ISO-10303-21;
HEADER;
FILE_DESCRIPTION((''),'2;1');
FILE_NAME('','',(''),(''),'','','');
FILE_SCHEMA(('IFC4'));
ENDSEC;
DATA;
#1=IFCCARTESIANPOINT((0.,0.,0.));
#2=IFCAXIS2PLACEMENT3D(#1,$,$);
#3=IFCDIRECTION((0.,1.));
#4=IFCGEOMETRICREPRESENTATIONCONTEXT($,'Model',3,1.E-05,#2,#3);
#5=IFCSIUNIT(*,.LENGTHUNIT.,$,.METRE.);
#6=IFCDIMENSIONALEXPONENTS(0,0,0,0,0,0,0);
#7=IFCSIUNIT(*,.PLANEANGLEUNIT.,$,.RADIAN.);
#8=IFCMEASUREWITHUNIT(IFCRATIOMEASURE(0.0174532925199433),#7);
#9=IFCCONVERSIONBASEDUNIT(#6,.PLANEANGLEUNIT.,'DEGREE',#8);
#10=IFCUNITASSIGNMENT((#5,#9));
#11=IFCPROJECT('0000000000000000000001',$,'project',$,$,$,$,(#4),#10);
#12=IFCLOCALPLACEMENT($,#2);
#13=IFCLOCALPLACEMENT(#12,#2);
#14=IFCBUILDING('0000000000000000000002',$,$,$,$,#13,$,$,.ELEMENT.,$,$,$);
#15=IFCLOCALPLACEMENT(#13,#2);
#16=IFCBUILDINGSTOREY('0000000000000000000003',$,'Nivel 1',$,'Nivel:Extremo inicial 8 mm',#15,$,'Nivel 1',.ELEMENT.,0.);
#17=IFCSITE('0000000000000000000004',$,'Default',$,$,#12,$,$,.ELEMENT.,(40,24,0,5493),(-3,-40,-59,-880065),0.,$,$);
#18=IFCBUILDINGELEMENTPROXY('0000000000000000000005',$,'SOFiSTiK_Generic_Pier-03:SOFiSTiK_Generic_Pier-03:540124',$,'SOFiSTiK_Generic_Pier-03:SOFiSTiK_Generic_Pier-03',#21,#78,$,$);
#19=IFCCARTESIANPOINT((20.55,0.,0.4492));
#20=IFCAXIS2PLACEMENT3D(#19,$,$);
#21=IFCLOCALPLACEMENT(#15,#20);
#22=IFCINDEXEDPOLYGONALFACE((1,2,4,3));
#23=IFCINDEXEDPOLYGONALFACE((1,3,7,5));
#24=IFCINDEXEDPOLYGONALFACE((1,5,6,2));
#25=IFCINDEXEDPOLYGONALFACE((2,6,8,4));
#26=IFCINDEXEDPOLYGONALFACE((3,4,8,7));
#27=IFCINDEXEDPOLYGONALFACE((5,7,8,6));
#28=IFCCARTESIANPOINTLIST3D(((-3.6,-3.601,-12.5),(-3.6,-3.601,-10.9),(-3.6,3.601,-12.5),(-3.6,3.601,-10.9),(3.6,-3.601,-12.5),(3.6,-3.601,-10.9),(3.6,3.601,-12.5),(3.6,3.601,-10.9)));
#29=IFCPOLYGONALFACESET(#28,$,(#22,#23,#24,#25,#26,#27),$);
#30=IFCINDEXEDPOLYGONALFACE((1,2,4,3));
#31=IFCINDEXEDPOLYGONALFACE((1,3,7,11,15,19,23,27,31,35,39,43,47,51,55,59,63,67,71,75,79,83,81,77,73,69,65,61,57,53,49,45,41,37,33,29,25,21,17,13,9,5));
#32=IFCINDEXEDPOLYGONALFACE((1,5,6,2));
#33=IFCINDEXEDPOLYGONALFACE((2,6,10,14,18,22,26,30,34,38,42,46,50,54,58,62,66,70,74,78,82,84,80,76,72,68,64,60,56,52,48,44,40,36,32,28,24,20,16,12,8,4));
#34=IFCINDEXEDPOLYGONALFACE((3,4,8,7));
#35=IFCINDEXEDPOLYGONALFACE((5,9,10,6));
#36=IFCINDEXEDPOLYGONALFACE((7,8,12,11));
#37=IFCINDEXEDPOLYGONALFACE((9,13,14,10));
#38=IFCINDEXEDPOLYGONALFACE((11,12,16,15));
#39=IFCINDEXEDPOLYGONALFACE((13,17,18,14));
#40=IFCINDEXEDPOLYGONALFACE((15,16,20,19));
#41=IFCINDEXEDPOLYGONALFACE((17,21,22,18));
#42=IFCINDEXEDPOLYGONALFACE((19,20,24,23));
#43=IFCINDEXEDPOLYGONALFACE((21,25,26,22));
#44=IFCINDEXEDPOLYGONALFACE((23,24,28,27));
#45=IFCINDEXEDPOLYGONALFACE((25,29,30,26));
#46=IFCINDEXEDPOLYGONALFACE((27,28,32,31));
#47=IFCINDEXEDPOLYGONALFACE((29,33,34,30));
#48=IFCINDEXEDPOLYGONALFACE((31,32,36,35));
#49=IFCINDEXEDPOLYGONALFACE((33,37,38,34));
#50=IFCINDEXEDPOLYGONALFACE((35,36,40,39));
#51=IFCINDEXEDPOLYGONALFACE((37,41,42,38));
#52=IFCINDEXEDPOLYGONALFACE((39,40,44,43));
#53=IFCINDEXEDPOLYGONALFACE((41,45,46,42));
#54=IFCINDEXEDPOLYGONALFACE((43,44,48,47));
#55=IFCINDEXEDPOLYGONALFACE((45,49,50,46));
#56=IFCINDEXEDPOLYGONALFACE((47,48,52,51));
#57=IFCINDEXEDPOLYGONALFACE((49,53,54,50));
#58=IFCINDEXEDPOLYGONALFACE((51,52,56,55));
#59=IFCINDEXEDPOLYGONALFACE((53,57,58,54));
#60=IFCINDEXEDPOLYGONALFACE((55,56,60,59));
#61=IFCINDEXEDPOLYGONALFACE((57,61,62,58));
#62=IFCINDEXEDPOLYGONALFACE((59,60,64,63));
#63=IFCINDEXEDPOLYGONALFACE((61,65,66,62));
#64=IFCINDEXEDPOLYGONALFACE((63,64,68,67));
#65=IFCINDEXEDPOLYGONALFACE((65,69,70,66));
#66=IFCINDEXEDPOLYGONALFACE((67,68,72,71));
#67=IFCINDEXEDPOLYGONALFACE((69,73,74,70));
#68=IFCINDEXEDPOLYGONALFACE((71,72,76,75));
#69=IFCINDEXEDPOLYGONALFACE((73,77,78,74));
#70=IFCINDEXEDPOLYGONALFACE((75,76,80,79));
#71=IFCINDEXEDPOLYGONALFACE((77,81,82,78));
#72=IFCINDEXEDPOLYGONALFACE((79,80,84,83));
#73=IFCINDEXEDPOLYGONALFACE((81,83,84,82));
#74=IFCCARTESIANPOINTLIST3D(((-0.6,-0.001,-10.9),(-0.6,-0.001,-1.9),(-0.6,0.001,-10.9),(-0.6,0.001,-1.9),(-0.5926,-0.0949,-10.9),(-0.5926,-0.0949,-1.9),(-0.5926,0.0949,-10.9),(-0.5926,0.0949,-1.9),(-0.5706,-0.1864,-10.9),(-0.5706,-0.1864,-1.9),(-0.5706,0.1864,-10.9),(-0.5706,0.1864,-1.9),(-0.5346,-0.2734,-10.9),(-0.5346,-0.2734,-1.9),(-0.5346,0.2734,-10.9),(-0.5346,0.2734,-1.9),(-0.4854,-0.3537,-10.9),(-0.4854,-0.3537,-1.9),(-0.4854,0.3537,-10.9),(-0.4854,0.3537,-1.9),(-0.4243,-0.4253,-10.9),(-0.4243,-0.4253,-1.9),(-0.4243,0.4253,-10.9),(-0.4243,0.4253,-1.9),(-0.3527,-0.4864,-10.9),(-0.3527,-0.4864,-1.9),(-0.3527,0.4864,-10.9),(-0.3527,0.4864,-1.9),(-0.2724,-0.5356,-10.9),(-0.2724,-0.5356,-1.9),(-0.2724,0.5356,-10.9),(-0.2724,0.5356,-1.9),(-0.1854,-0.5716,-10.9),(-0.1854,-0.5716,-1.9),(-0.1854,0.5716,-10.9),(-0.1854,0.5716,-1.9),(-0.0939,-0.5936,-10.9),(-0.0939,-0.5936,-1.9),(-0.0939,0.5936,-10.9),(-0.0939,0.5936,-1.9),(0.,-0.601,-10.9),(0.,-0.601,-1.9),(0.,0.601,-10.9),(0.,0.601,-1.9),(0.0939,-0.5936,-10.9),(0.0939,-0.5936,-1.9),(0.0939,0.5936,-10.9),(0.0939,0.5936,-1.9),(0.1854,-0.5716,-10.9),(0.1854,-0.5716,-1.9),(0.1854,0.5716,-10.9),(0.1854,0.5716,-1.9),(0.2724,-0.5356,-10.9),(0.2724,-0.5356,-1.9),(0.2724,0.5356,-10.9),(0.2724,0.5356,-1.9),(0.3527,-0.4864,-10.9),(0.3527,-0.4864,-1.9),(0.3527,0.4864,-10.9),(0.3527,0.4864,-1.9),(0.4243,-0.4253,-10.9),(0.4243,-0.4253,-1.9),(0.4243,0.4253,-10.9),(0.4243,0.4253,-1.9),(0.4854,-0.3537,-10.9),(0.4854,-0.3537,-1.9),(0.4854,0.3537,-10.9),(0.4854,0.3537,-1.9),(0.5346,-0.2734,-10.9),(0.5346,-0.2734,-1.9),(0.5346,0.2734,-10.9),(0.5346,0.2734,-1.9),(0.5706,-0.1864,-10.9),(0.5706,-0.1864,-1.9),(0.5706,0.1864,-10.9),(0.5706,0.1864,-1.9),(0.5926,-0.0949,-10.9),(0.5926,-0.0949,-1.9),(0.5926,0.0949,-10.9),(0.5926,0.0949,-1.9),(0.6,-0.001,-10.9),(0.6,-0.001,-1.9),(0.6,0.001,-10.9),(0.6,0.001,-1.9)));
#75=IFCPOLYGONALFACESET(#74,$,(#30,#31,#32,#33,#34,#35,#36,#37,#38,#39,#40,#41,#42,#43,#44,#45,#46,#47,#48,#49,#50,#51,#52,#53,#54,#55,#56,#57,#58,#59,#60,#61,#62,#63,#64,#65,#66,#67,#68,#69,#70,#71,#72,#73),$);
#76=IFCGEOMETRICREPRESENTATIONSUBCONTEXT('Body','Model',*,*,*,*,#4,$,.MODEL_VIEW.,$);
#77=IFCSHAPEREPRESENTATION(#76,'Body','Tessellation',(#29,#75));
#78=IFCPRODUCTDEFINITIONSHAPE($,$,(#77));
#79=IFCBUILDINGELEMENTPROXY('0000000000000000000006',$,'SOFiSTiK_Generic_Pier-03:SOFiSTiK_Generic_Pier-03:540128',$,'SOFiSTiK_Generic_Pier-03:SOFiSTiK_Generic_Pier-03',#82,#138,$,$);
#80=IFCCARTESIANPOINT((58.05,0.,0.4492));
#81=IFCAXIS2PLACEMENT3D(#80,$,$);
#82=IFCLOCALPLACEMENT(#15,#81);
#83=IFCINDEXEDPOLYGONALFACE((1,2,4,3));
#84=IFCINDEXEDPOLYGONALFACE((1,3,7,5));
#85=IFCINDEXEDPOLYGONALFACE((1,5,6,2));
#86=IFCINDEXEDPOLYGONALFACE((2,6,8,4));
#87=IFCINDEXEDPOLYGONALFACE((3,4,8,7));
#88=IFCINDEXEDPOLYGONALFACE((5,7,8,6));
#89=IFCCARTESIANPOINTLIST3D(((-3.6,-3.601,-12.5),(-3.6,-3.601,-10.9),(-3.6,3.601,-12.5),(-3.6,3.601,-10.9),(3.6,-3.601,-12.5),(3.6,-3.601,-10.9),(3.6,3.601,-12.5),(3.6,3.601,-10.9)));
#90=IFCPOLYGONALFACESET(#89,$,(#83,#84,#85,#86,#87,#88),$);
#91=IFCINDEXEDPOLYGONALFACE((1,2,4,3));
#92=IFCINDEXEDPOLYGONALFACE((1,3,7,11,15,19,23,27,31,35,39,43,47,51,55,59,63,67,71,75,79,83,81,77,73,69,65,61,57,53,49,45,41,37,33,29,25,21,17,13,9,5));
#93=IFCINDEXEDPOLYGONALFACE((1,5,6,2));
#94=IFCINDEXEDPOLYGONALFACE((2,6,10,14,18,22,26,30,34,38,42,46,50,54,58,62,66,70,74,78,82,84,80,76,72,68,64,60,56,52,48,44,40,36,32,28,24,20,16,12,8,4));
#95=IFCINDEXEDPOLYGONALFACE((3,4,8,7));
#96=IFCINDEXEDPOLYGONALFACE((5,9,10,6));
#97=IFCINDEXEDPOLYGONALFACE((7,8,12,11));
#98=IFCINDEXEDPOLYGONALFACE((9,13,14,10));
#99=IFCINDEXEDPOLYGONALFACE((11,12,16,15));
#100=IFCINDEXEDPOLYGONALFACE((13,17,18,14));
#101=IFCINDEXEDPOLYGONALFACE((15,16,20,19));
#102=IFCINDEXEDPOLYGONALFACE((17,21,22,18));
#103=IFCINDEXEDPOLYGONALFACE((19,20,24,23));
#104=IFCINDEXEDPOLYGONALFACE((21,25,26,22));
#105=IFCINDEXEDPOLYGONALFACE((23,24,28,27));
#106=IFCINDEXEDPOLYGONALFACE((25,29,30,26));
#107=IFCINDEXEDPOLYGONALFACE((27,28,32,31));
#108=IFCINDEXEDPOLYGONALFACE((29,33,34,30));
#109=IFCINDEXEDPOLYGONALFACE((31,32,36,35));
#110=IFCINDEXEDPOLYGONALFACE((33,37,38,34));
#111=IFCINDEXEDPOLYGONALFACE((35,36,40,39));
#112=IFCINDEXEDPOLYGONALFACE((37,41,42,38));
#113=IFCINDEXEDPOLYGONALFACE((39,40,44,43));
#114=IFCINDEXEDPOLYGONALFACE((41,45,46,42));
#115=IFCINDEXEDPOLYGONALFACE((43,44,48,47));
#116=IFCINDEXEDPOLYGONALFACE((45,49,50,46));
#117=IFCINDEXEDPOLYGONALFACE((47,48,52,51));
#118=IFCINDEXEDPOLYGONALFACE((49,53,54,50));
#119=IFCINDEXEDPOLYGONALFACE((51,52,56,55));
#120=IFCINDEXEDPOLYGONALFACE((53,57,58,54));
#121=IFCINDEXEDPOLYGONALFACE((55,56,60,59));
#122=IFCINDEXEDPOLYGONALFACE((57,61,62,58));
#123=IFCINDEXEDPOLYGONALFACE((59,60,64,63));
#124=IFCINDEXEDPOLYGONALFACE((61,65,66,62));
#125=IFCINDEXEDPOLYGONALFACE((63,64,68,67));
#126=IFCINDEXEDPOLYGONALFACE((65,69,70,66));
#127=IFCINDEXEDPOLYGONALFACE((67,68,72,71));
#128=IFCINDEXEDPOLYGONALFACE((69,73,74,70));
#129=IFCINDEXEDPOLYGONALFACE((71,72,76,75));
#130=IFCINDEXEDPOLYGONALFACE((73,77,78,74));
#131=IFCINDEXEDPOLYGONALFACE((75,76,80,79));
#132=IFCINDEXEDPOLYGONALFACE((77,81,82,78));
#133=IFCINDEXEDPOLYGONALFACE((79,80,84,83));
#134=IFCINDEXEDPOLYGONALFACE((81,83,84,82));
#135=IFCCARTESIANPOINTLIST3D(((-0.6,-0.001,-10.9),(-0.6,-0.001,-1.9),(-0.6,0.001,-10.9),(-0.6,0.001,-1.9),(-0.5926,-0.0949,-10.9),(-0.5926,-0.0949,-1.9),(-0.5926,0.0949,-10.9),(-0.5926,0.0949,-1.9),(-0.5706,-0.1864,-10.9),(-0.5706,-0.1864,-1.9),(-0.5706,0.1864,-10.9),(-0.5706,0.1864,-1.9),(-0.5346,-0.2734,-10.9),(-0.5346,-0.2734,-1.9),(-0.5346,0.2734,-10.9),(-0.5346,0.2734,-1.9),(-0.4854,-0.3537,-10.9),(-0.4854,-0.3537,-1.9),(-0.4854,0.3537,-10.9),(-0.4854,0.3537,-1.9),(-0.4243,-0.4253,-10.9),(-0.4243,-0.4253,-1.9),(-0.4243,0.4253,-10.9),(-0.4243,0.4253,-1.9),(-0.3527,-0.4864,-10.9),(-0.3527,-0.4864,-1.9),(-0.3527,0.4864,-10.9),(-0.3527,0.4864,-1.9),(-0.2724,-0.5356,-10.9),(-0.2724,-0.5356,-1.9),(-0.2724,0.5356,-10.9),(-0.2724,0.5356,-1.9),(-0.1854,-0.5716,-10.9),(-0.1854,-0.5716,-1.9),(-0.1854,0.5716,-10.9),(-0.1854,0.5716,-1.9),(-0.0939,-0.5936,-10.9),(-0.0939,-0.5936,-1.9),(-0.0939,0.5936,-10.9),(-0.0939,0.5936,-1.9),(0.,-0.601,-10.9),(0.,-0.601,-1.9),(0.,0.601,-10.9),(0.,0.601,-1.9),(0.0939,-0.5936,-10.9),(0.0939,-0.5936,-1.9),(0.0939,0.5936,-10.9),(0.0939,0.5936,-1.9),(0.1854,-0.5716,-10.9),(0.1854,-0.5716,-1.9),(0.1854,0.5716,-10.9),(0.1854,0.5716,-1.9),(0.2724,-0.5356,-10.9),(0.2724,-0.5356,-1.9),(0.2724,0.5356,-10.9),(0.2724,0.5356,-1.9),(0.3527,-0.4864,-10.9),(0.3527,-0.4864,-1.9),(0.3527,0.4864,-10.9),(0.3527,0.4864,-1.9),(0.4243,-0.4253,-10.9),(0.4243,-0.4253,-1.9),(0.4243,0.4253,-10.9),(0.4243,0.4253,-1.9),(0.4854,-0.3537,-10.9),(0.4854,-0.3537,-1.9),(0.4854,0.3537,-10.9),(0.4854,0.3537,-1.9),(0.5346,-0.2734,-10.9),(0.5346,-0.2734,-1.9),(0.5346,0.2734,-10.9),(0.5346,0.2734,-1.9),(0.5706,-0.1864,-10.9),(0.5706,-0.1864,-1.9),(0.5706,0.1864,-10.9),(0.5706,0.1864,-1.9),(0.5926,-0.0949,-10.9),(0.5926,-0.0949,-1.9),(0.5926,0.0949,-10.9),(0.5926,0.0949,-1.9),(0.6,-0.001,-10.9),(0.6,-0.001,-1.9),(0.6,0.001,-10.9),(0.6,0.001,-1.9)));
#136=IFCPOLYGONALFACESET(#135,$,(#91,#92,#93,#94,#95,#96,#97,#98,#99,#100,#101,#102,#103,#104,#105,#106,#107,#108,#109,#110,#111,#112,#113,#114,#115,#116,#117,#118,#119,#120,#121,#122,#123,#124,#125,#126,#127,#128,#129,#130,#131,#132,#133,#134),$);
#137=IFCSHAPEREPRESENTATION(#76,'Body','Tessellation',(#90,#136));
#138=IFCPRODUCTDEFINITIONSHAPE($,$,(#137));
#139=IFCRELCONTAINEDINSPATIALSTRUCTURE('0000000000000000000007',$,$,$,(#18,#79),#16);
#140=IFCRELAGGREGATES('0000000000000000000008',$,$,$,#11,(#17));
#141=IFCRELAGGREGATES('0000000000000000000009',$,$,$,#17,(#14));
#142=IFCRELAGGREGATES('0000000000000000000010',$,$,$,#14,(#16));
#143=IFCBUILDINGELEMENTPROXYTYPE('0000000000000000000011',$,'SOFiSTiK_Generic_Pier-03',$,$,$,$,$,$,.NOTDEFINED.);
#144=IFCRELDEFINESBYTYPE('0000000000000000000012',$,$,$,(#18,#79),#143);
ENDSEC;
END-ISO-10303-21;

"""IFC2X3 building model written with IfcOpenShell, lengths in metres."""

from ifc_helpers import new_model, entity, si_unit, converted_unit, direction, frame, frame_2d, origin, place, context, subcontext, project, spatial, polyline, circle_curve, parameter, trimmed, segment, composite_curve, rectangle, outline, extrude, source, transform, mapped, type_object, type_shapes, element, save


model = new_model("IFC2X3")

# Units and contexts
model_context = context("Model", 3, precision=1e-05, world=origin(), true_north=direction((0.0, 1.0)))
body_context = subcontext(model_context, "Body", "Model", "MODEL_VIEW")
ifc_project = project(units=[si_unit("LENGTHUNIT", "METRE"), converted_unit("PLANEANGLEUNIT", "DEGREE", entity("IfcRatioMeasure", 0.0174532925199433), si_unit("PLANEANGLEUNIT", "RADIAN"), dimensions=[0, 0, 0, 0, 0, 0, 0])], contexts=[model_context])

# Site, building, storey
site_placement = place(None, origin())
site = spatial("IfcSite", under=ifc_project, at=site_placement, Name="Default", CompositionType="ELEMENT", RefLatitude=(40, 24, 0, 5493), RefLongitude=(-3, -40, -59, -880065), RefElevation=0.0)
building_placement = place(site_placement, origin())
building = spatial("IfcBuilding", under=site, at=building_placement, CompositionType="ELEMENT")
storey_placement = place(building_placement, origin())
storey = spatial("IfcBuildingStorey", under=building, at=storey_placement, Name="Nivel 1", ObjectType="Nivel:Extremo inicial 8 mm", LongName="Nivel 1", CompositionType="ELEMENT", Elevation=0.0)

# Building element proxies
building_element_proxy_type = type_object("IfcBuildingElementProxyType", Name="SOFiSTiK_Generic_Pier-03", PredefinedType="NOTDEFINED")
shared_shape = source(origin(), body_context, "Body", "SweptSolid", [
    extrude(rectangle(XDim=7.2, YDim=7.202, at=frame_2d((0.0, 0.0), x_axis=(1.0, 0.0))), frame((0.0, 0.0, -12.5)), (0.0, 0.0, 1.0), 1.6),
    extrude(outline(composite_curve([segment(trimmed(circle_curve(frame_2d((0.001, 0.0), x_axis=(1.0, 0.0)), 0.6), [parameter(270.0)], [parameter(90.0)], True, "PARAMETER"), True, "CONTINUOUS"), segment(polyline([(0.001, 0.6), (-0.001, 0.6)]), True, "CONTINUOUS"), segment(trimmed(circle_curve(frame_2d((-0.001, 0.0), x_axis=(-1.0, 0.0)), 0.6), [parameter(270.0)], [parameter(90.0)], True, "PARAMETER"), True, "CONTINUOUS"), segment(polyline([(-0.001, -0.6), (0.001, -0.6)]), True, "CONTINUOUS")], self_intersect=False)), frame((0.0, 0.0, -10.9), z_axis=(0.0, 0.0, 1.0), x_axis=(0.0, -1.0, 0.0)), (0.0, 0.0, 1.0), 9.0),
])
type_shapes(building_element_proxy_type, [shared_shape])
for number, where, name in (
    (1, (20.55, 0.0, 0.4492), "SOFiSTiK_Generic_Pier-03:SOFiSTiK_Generic_Pier-03:540124"),
    (2, (58.05, 0.0, 0.4492), "SOFiSTiK_Generic_Pier-03:SOFiSTiK_Generic_Pier-03:540128"),
):
    element("IfcBuildingElementProxy", number, at=place(storey_placement, frame(where)), inside=storey, type_object=building_element_proxy_type, Name=name, ObjectType="SOFiSTiK_Generic_Pier-03:SOFiSTiK_Generic_Pier-03", context=body_context, shape_type="MappedRepresentation", body=[
        mapped(shared_shape, transform((0.0, 0.0, 0.0), scale=1.0)),
    ])

save(model, "model.ifc")
